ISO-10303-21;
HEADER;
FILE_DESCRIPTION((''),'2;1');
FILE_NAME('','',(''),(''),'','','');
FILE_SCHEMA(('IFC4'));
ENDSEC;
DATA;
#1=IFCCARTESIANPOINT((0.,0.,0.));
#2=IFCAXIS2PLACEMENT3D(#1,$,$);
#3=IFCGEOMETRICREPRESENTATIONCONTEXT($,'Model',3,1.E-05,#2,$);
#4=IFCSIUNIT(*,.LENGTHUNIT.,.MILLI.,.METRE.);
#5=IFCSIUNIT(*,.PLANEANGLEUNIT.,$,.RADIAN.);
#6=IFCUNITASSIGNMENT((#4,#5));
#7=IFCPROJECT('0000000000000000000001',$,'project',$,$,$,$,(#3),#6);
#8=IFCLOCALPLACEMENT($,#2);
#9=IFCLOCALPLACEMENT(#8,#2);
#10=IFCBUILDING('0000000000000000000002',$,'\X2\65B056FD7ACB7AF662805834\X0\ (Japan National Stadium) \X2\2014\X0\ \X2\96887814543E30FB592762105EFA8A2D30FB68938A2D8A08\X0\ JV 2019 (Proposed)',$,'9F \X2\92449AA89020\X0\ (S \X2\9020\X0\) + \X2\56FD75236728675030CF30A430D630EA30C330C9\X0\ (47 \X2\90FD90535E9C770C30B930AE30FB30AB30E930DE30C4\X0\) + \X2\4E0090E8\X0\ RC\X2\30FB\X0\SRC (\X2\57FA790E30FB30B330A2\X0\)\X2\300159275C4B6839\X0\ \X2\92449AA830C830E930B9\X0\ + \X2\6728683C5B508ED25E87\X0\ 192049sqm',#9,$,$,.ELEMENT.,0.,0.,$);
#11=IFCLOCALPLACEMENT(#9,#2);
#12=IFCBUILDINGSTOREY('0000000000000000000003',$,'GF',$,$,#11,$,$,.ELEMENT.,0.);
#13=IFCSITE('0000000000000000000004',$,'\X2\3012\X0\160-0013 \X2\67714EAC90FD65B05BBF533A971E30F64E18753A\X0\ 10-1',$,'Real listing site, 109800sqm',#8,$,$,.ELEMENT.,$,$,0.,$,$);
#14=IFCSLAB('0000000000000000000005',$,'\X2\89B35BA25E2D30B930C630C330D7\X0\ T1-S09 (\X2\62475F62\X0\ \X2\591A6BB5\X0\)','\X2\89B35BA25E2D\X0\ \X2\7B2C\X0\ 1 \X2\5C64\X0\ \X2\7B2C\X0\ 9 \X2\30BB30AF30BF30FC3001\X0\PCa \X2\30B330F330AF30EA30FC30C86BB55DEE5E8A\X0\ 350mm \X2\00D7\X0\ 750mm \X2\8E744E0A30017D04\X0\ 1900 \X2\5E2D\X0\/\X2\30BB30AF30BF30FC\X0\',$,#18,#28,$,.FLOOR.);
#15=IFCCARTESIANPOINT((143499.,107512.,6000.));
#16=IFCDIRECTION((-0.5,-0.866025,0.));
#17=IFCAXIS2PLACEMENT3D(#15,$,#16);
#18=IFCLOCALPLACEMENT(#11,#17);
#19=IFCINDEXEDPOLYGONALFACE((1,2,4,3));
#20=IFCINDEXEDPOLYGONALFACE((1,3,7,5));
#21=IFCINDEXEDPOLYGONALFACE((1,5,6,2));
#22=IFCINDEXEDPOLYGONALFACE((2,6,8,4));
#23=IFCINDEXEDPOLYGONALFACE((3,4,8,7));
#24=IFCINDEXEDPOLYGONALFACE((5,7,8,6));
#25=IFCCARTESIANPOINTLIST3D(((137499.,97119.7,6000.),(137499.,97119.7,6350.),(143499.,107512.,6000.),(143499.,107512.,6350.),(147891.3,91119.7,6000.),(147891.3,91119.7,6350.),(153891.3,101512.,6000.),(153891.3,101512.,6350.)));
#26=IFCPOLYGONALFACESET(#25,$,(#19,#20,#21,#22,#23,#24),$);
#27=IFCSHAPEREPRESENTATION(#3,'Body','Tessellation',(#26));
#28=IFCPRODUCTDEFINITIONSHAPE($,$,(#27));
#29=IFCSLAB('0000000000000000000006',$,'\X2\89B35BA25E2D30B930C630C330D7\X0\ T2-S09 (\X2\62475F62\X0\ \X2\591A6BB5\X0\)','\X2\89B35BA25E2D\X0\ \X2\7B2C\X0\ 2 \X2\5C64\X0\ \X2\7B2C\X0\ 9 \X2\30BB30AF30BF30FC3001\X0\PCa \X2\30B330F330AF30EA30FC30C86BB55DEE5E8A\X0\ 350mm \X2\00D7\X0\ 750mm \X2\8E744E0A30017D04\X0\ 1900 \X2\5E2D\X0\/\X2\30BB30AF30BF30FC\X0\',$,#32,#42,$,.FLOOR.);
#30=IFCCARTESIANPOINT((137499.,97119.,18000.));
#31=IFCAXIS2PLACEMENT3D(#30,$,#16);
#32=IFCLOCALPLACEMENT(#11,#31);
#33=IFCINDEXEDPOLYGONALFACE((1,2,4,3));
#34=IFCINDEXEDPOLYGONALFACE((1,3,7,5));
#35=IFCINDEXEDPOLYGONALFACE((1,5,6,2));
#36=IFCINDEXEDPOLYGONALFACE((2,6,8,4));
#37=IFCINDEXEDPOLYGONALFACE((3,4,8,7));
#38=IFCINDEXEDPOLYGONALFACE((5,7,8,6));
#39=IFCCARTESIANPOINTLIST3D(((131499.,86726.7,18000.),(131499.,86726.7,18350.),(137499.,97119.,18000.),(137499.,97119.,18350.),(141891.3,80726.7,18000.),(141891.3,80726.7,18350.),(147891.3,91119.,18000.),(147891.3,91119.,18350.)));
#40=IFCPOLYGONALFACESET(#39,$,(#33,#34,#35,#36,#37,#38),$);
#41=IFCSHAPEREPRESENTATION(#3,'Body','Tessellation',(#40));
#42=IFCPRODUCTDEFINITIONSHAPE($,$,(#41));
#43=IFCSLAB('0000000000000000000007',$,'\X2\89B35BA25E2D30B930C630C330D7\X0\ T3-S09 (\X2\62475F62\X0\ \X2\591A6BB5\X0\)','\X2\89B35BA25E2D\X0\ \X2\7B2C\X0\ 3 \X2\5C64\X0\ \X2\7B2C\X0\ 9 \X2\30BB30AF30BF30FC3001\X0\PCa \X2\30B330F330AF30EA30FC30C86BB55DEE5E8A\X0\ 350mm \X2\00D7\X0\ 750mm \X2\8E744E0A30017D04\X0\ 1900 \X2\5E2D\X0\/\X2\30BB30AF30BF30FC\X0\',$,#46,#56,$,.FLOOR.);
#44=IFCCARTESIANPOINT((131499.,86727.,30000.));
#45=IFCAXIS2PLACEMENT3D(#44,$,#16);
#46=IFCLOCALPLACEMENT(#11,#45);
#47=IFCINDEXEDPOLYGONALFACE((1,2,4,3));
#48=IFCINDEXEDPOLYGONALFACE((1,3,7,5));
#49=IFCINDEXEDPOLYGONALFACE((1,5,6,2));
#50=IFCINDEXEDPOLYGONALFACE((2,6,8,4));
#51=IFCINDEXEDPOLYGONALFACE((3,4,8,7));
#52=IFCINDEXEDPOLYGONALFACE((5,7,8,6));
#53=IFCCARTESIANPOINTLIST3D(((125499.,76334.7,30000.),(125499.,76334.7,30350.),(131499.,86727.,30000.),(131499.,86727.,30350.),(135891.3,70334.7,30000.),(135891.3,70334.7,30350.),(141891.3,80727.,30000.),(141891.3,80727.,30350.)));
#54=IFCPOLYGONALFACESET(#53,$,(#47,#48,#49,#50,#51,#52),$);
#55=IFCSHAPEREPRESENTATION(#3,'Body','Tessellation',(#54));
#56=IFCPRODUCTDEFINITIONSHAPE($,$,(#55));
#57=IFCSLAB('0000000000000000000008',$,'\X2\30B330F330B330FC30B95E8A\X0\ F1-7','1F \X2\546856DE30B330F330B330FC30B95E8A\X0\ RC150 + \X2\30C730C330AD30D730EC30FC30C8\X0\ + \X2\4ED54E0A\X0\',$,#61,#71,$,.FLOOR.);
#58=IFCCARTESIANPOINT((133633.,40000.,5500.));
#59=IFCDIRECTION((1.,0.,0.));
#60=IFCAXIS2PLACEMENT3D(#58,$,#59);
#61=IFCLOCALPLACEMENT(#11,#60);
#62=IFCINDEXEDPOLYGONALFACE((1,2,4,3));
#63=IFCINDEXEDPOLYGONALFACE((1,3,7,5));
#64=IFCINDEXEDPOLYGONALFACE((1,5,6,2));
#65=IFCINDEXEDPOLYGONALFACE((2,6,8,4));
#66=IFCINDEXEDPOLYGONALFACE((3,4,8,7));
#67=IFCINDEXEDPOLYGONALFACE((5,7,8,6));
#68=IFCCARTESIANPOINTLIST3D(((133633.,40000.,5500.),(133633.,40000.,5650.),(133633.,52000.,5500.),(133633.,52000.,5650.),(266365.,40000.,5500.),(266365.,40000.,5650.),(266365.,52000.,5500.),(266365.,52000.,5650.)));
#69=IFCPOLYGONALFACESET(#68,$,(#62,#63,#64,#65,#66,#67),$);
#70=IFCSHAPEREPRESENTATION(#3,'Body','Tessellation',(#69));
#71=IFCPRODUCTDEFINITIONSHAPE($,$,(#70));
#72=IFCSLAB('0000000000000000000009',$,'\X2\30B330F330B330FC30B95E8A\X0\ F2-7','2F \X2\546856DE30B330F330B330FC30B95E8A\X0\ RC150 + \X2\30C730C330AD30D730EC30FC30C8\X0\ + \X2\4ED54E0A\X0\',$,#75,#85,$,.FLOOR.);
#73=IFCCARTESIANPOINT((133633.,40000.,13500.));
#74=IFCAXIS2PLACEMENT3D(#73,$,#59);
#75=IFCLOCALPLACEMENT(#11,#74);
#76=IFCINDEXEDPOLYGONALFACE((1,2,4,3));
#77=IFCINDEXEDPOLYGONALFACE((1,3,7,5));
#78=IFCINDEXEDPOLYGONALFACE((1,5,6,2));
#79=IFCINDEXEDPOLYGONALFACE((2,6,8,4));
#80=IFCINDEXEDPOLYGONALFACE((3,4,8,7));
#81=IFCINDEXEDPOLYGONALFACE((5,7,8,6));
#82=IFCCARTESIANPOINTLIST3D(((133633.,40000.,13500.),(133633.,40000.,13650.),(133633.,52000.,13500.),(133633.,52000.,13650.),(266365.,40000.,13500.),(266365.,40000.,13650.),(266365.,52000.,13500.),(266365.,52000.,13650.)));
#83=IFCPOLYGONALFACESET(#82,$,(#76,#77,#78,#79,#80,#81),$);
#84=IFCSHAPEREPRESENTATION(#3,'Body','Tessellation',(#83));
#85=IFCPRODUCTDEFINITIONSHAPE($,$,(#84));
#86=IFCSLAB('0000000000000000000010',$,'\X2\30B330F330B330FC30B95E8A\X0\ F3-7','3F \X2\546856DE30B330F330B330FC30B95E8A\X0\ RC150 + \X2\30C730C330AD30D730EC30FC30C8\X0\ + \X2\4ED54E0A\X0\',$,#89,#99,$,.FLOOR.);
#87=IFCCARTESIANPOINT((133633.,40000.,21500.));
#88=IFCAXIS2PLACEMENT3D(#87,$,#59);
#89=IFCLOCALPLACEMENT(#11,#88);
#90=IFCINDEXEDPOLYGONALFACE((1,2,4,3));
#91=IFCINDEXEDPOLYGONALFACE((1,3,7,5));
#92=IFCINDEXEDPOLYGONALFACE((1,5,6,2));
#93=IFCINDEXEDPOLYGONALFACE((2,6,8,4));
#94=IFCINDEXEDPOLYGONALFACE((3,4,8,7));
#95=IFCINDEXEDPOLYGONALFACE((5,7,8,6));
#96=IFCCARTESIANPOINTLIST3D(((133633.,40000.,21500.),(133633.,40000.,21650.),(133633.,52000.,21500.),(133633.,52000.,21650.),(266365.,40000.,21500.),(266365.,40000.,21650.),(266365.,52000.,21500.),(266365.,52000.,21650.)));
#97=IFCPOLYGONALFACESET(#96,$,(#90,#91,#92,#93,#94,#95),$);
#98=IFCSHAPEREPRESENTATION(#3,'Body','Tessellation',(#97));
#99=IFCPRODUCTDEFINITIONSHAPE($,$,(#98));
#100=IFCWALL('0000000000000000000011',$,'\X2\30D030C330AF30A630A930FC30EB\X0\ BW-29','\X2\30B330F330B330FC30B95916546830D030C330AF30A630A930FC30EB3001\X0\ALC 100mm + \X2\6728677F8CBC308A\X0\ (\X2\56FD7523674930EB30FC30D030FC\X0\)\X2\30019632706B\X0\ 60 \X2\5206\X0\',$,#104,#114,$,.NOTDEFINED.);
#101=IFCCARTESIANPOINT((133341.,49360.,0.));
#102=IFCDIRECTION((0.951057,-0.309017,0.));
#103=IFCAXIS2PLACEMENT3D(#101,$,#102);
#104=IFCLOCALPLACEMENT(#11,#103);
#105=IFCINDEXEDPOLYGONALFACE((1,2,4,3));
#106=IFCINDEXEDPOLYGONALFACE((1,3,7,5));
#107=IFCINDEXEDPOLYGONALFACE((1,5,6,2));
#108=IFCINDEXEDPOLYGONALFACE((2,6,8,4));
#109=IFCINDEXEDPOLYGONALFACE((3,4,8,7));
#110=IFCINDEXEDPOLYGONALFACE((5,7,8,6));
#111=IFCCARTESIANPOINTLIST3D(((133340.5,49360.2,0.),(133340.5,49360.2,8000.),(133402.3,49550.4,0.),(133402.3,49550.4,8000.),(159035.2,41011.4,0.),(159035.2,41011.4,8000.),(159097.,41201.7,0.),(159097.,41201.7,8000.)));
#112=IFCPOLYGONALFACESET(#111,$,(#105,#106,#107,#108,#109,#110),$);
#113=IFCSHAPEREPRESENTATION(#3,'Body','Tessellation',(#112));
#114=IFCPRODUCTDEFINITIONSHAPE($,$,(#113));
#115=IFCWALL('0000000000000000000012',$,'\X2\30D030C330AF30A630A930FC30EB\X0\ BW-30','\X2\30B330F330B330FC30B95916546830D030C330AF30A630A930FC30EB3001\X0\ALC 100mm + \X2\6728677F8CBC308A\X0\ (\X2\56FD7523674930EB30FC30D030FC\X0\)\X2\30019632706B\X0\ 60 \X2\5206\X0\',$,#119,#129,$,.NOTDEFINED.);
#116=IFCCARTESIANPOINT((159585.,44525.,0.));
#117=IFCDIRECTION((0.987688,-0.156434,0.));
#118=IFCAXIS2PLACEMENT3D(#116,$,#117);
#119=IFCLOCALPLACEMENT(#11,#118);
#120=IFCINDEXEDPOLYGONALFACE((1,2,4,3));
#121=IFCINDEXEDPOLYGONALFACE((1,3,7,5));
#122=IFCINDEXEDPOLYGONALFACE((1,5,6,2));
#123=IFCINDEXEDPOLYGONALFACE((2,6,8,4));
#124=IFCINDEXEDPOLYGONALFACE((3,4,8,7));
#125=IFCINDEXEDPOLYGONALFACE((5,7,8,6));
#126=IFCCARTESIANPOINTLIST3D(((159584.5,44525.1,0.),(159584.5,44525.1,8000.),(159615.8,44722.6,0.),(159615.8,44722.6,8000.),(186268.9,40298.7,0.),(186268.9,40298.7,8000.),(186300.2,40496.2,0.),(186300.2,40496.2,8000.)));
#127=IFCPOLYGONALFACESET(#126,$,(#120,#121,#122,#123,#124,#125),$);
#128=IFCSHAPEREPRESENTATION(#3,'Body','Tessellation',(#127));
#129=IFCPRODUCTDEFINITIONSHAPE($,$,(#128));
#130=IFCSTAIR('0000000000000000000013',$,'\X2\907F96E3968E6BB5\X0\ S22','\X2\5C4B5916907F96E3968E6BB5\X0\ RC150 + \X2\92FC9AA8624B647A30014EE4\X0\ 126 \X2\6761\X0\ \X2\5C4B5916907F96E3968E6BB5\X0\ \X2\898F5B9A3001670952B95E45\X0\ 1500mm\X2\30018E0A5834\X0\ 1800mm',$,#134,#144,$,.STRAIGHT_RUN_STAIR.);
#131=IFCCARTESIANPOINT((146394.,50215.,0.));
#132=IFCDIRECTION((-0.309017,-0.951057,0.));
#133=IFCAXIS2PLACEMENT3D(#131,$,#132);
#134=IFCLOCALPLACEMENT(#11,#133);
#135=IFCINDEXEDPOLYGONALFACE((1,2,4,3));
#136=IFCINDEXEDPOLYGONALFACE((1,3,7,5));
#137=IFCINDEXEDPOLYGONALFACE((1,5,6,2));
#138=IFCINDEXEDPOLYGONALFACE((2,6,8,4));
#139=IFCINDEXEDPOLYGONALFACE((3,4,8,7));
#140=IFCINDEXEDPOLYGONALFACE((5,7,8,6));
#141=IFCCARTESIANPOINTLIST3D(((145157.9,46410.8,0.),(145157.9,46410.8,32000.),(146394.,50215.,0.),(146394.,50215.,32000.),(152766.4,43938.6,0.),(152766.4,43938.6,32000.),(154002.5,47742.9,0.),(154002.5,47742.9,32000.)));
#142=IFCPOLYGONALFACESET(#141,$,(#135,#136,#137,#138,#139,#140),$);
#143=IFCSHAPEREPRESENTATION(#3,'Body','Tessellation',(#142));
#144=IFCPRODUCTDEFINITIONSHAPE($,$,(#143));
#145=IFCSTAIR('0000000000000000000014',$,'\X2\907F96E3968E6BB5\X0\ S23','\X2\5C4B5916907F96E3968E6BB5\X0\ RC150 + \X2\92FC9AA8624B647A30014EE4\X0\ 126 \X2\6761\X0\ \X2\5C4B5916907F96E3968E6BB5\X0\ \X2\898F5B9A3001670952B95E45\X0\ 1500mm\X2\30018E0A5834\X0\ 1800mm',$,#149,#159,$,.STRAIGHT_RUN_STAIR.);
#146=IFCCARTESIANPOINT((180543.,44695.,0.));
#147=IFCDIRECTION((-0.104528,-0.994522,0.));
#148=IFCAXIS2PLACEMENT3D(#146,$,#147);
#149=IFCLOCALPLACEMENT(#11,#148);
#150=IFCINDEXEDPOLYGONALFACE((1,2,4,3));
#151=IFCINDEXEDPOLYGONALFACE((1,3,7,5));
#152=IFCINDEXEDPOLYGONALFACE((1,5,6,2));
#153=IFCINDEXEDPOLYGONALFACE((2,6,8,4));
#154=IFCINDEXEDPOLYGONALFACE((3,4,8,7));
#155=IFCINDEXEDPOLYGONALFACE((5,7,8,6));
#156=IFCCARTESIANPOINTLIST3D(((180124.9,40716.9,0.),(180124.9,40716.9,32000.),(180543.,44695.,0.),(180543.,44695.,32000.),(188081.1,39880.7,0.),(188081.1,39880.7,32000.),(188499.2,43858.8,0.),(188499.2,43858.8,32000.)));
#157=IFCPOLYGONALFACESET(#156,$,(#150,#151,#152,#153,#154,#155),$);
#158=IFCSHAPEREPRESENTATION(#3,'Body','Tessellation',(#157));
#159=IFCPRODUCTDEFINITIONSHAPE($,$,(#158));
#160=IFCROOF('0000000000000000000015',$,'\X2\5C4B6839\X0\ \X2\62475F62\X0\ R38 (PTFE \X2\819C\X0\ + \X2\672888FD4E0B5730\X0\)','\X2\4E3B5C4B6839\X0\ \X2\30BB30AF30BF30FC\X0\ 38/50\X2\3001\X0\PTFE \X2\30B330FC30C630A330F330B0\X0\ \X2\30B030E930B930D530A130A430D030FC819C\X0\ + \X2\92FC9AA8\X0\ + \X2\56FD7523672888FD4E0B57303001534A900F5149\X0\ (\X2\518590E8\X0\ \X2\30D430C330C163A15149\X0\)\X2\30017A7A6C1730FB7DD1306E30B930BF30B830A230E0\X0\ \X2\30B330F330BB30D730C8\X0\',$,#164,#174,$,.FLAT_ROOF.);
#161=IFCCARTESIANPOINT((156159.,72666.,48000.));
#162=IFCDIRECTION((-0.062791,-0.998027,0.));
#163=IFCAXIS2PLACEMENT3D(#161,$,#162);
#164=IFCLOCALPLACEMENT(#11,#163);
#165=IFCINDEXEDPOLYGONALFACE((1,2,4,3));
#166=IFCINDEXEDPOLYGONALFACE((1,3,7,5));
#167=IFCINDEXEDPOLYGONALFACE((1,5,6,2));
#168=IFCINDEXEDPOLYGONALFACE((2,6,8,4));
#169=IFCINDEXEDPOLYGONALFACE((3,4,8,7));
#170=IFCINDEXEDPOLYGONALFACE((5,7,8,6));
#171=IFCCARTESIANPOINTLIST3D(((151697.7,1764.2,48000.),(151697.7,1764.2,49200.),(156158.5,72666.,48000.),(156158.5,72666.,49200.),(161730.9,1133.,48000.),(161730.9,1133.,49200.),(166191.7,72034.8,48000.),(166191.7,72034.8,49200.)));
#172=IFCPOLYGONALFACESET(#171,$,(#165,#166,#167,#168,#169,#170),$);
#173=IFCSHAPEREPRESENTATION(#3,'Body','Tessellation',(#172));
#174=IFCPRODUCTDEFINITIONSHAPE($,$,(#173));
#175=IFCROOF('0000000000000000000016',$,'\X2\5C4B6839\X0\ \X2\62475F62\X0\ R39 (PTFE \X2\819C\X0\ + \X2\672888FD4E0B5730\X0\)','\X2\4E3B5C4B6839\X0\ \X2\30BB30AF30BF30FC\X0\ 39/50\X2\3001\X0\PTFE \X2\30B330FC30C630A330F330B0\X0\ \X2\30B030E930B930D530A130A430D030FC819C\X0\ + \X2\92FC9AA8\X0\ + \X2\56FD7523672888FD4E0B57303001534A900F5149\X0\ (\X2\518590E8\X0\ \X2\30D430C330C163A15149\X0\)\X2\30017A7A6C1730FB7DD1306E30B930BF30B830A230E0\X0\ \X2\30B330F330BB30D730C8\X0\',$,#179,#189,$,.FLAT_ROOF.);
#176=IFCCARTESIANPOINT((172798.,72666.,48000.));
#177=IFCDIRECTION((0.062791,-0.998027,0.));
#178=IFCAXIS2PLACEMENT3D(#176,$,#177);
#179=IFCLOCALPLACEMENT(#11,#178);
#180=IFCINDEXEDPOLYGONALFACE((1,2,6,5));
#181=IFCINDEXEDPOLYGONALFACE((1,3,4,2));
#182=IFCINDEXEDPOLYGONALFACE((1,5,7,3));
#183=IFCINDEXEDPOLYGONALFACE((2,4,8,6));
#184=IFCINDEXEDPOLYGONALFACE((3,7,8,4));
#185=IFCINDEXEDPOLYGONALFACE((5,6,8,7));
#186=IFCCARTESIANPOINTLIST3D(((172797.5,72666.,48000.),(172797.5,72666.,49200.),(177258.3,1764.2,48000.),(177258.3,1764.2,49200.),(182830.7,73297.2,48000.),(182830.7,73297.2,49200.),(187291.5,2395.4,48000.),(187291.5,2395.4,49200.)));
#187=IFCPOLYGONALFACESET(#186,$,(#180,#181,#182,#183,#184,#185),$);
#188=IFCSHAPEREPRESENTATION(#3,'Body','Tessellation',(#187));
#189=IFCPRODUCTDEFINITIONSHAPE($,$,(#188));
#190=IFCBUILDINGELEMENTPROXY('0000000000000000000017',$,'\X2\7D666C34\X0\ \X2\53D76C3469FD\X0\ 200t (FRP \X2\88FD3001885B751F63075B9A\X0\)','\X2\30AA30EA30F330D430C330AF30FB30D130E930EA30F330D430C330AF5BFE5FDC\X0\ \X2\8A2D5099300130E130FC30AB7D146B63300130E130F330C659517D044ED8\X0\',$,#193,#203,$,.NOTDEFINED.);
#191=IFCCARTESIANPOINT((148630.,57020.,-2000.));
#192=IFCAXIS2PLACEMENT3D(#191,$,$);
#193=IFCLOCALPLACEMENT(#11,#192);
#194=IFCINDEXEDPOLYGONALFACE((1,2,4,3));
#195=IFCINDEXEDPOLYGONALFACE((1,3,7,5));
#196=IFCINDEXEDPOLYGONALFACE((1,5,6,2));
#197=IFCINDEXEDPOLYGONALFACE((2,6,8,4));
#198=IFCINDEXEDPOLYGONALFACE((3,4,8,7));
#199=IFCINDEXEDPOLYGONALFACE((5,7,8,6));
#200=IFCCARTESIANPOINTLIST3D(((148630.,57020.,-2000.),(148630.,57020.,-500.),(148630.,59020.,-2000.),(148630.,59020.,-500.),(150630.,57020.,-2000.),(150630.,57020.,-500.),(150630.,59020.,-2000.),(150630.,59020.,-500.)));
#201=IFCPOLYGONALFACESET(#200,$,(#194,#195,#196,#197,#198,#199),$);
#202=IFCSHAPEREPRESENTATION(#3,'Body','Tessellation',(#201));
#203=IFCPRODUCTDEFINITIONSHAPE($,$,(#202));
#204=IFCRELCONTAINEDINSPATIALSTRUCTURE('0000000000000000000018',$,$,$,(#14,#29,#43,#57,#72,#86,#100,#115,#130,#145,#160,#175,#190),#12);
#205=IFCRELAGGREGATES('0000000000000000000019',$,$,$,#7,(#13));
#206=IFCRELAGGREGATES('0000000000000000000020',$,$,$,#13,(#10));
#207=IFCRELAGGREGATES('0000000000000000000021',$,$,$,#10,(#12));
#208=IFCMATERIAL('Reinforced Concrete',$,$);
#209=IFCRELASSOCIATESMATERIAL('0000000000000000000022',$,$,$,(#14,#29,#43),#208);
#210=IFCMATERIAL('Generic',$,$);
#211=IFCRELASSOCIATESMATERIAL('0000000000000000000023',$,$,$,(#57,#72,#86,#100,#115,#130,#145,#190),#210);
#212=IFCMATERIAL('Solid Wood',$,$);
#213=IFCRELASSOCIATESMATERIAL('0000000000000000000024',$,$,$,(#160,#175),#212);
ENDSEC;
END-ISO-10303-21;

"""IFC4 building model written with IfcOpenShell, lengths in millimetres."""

from ifc_helpers import new_model, si_unit, frame, frame_2d, origin, place, context, project, spatial, rectangle, extrude, material, element, save


model = new_model("IFC4")

# Units and contexts
model_context = context("Model", 3, precision=1e-05, world=origin())
ifc_project = project(units=[si_unit("LENGTHUNIT", "METRE", prefix="MILLI"), si_unit("PLANEANGLEUNIT", "RADIAN")], contexts=[model_context])

# Site, building, storey
site_placement = place(None, origin())
site = spatial("IfcSite", under=ifc_project, at=site_placement, Name="〒160-0013 東京都新宿区霞ヶ丘町 10-1", ObjectType="Real listing site, 109800sqm", CompositionType="ELEMENT", RefElevation=0.0)
building_placement = place(site_placement, origin())
building = spatial("IfcBuilding", under=site, at=building_placement, Name="新国立競技場 (Japan National Stadium) — 隈研吾・大成建設・梓設計 JV 2019 (Proposed)", ObjectType="9F 鉄骨造 (S 造) + 国産木材ハイブリッド (47 都道府県スギ・カラマツ) + 一部 RC・SRC (基礎・コア)、大屋根 鉄骨トラス + 木格子軒庇 192049sqm", CompositionType="ELEMENT", ElevationOfRefHeight=0.0, ElevationOfTerrain=0.0)
storey_placement = place(building_placement, origin())
storey = spatial("IfcBuildingStorey", under=building, at=storey_placement, Name="GF", CompositionType="ELEMENT", Elevation=0.0)

# Shared definitions
ifc_material_1 = material(Name="Reinforced Concrete")
ifc_material_2 = material(Name="Generic")

# Shared definitions
ifc_material_3 = material(Name="Solid Wood")

# Slabs
slab_1_placement = place(storey_placement, frame((143499.0, 107512.0, 6000.0), x_axis=(-0.5, -0.866025, 0.0)))
element("IfcSlab", 1, at=slab_1_placement, inside=storey, material=ifc_material_1, Name="観客席ステップ T1-S09 (扇形 多段)", Description="観客席 第 1 層 第 9 セクター、PCa コンクリート段差床 350mm × 750mm 蹴上、約 1900 席/セクター", PredefinedType="FLOOR", context=model_context, shape_type="SweptSolid", body=[
    extrude(rectangle(XDim=12000.0, YDim=12000.0, at=frame_2d((6000.0, 6000.0))), frame((143499.0, 107512.0, 6000.0), x_axis=(-0.5, -0.866025, 0.0)), (0.0, 0.0, 1.0), 350.0),
])
slab_2_placement = place(storey_placement, frame((137499.0, 97119.0, 18000.0), x_axis=(-0.5, -0.866025, 0.0)))
element("IfcSlab", 2, at=slab_2_placement, inside=storey, material=ifc_material_1, Name="観客席ステップ T2-S09 (扇形 多段)", Description="観客席 第 2 層 第 9 セクター、PCa コンクリート段差床 350mm × 750mm 蹴上、約 1900 席/セクター", PredefinedType="FLOOR", context=model_context, shape_type="SweptSolid", body=[
    extrude(rectangle(XDim=12000.0, YDim=12000.0, at=frame_2d((6000.0, 6000.0))), frame((137499.0, 97119.0, 18000.0), x_axis=(-0.5, -0.866025, 0.0)), (0.0, 0.0, 1.0), 350.0),
])
slab_3_placement = place(storey_placement, frame((131499.0, 86727.0, 30000.0), x_axis=(-0.5, -0.866025, 0.0)))
element("IfcSlab", 3, at=slab_3_placement, inside=storey, material=ifc_material_1, Name="観客席ステップ T3-S09 (扇形 多段)", Description="観客席 第 3 層 第 9 セクター、PCa コンクリート段差床 350mm × 750mm 蹴上、約 1900 席/セクター", PredefinedType="FLOOR", context=model_context, shape_type="SweptSolid", body=[
    extrude(rectangle(XDim=12000.0, YDim=12000.0, at=frame_2d((6000.0, 6000.0))), frame((131499.0, 86727.0, 30000.0), x_axis=(-0.5, -0.866025, 0.0)), (0.0, 0.0, 1.0), 350.0),
])
slab_4_placement = place(storey_placement, frame((133633.0, 40000.0, 5500.0), x_axis=(1.0, 0.0, 0.0)))
element("IfcSlab", 4, at=slab_4_placement, inside=storey, material=ifc_material_2, Name="コンコース床 F1-7", Description="1F 周回コンコース床 RC150 + デッキプレート + 仕上", PredefinedType="FLOOR", context=model_context, shape_type="SweptSolid", body=[
    extrude(rectangle(XDim=132732.0, YDim=12000.0, at=frame_2d((66366.0, 6000.0))), frame((133633.0, 40000.0, 5500.0), x_axis=(1.0, 0.0, 0.0)), (0.0, 0.0, 1.0), 150.0),
])
slab_5_placement = place(storey_placement, frame((133633.0, 40000.0, 13500.0), x_axis=(1.0, 0.0, 0.0)))
element("IfcSlab", 5, at=slab_5_placement, inside=storey, material=ifc_material_2, Name="コンコース床 F2-7", Description="2F 周回コンコース床 RC150 + デッキプレート + 仕上", PredefinedType="FLOOR", context=model_context, shape_type="SweptSolid", body=[
    extrude(rectangle(XDim=132732.0, YDim=12000.0, at=frame_2d((66366.0, 6000.0))), frame((133633.0, 40000.0, 13500.0), x_axis=(1.0, 0.0, 0.0)), (0.0, 0.0, 1.0), 150.0),
])
slab_6_placement = place(storey_placement, frame((133633.0, 40000.0, 21500.0), x_axis=(1.0, 0.0, 0.0)))
element("IfcSlab", 6, at=slab_6_placement, inside=storey, material=ifc_material_2, Name="コンコース床 F3-7", Description="3F 周回コンコース床 RC150 + デッキプレート + 仕上", PredefinedType="FLOOR", context=model_context, shape_type="SweptSolid", body=[
    extrude(rectangle(XDim=132732.0, YDim=12000.0, at=frame_2d((66366.0, 6000.0))), frame((133633.0, 40000.0, 21500.0), x_axis=(1.0, 0.0, 0.0)), (0.0, 0.0, 1.0), 150.0),
])

# Walls
wall_1_placement = place(storey_placement, frame((133341.0, 49360.0, 0.0), x_axis=(0.951057, -0.309017, 0.0)))
element("IfcWall", 7, at=wall_1_placement, inside=storey, material=ifc_material_2, Name="バックウォール BW-29", Description="コンコース外周バックウォール、ALC 100mm + 木板貼り (国産杉ルーバー)、防火 60 分", PredefinedType="NOTDEFINED", context=model_context, shape_type="SweptSolid", body=[
    extrude(rectangle(XDim=27017.0, YDim=200.0, at=frame_2d((13508.0, 100.0))), frame((133341.0, 49360.0, 0.0), x_axis=(0.951057, -0.309017, 0.0)), (0.0, 0.0, 1.0), 8000.0),
])
wall_2_placement = place(storey_placement, frame((159585.0, 44525.0, 0.0), x_axis=(0.987688, -0.156434, 0.0)))
element("IfcWall", 8, at=wall_2_placement, inside=storey, material=ifc_material_2, Name="バックウォール BW-30", Description="コンコース外周バックウォール、ALC 100mm + 木板貼り (国産杉ルーバー)、防火 60 分", PredefinedType="NOTDEFINED", context=model_context, shape_type="SweptSolid", body=[
    extrude(rectangle(XDim=27017.0, YDim=200.0, at=frame_2d((13508.0, 100.0))), frame((159585.0, 44525.0, 0.0), x_axis=(0.987688, -0.156434, 0.0)), (0.0, 0.0, 1.0), 8000.0),
])

# Stairs
stair_1_placement = place(storey_placement, frame((146394.0, 50215.0, 0.0), x_axis=(-0.309017, -0.951057, 0.0)))
element("IfcStair", 9, at=stair_1_placement, inside=storey, material=ifc_material_2, Name="避難階段 S22", Description="屋外避難階段 RC150 + 鋼骨手摺、令 126 条 屋外避難階段 規定、有効幅 1500mm、踊場 1800mm", PredefinedType="STRAIGHT_RUN_STAIR", context=model_context, shape_type="SweptSolid", body=[
    extrude(rectangle(XDim=4000.0, YDim=8000.0, at=frame_2d((2000.0, 4000.0))), frame((146394.0, 50215.0, 0.0), x_axis=(-0.309017, -0.951057, 0.0)), (0.0, 0.0, 1.0), 32000.0),
])
stair_2_placement = place(storey_placement, frame((180543.0, 44695.0, 0.0), x_axis=(-0.104528, -0.994522, 0.0)))
element("IfcStair", 10, at=stair_2_placement, inside=storey, material=ifc_material_2, Name="避難階段 S23", Description="屋外避難階段 RC150 + 鋼骨手摺、令 126 条 屋外避難階段 規定、有効幅 1500mm、踊場 1800mm", PredefinedType="STRAIGHT_RUN_STAIR", context=model_context, shape_type="SweptSolid", body=[
    extrude(rectangle(XDim=4000.0, YDim=8000.0, at=frame_2d((2000.0, 4000.0))), frame((180543.0, 44695.0, 0.0), x_axis=(-0.104528, -0.994522, 0.0)), (0.0, 0.0, 1.0), 32000.0),
])

# Roofs
roof_1_placement = place(storey_placement, frame((156159.0, 72666.0, 48000.0), x_axis=(-0.062791, -0.998027, 0.0)))
element("IfcRoof", 11, at=roof_1_placement, inside=storey, material=ifc_material_3, Name="屋根 扇形 R38 (PTFE 膜 + 木製下地)", Description="主屋根 セクター 38/50、PTFE コーティング グラスファイバー膜 + 鋼骨 + 国産木製下地、半透光 (内部 ピッチ採光)、空気・緑のスタジアム コンセプト", PredefinedType="FLAT_ROOF", context=model_context, shape_type="SweptSolid", body=[
    extrude(rectangle(XDim=71042.0, YDim=10053.0, at=frame_2d((35521.0, 5026.0))), frame((156159.0, 72666.0, 48000.0), x_axis=(-0.062791, -0.998027, 0.0)), (0.0, 0.0, 1.0), 1200.0),
])
roof_2_placement = place(storey_placement, frame((172798.0, 72666.0, 48000.0), x_axis=(0.062791, -0.998027, 0.0)))
element("IfcRoof", 12, at=roof_2_placement, inside=storey, material=ifc_material_3, Name="屋根 扇形 R39 (PTFE 膜 + 木製下地)", Description="主屋根 セクター 39/50、PTFE コーティング グラスファイバー膜 + 鋼骨 + 国産木製下地、半透光 (内部 ピッチ採光)、空気・緑のスタジアム コンセプト", PredefinedType="FLAT_ROOF", context=model_context, shape_type="SweptSolid", body=[
    extrude(rectangle(XDim=71042.0, YDim=10053.0, at=frame_2d((35521.0, 5026.0))), frame((172798.0, 72666.0, 48000.0), x_axis=(0.062791, -0.998027, 0.0)), (0.0, 0.0, 1.0), 1200.0),
])

# Building element proxy
proxy_placement = place(storey_placement, frame((148630.0, 57020.0, -2000.0)))
element("IfcBuildingElementProxy", 13, at=proxy_placement, inside=storey, material=ifc_material_2, Name="給水 受水槽 200t (FRP 製、衛生指定)", Description="オリンピック・パラリンピック対応 設備、メーカ純正、メンテ契約付", PredefinedType="NOTDEFINED", context=model_context, shape_type="SweptSolid", body=[
    extrude(rectangle(XDim=2000.0, YDim=2000.0, at=frame_2d((1000.0, 1000.0))), frame((148630.0, 57020.0, -2000.0)), (0.0, 0.0, 1.0), 1500.0),
])

save(model, "model.ifc")
